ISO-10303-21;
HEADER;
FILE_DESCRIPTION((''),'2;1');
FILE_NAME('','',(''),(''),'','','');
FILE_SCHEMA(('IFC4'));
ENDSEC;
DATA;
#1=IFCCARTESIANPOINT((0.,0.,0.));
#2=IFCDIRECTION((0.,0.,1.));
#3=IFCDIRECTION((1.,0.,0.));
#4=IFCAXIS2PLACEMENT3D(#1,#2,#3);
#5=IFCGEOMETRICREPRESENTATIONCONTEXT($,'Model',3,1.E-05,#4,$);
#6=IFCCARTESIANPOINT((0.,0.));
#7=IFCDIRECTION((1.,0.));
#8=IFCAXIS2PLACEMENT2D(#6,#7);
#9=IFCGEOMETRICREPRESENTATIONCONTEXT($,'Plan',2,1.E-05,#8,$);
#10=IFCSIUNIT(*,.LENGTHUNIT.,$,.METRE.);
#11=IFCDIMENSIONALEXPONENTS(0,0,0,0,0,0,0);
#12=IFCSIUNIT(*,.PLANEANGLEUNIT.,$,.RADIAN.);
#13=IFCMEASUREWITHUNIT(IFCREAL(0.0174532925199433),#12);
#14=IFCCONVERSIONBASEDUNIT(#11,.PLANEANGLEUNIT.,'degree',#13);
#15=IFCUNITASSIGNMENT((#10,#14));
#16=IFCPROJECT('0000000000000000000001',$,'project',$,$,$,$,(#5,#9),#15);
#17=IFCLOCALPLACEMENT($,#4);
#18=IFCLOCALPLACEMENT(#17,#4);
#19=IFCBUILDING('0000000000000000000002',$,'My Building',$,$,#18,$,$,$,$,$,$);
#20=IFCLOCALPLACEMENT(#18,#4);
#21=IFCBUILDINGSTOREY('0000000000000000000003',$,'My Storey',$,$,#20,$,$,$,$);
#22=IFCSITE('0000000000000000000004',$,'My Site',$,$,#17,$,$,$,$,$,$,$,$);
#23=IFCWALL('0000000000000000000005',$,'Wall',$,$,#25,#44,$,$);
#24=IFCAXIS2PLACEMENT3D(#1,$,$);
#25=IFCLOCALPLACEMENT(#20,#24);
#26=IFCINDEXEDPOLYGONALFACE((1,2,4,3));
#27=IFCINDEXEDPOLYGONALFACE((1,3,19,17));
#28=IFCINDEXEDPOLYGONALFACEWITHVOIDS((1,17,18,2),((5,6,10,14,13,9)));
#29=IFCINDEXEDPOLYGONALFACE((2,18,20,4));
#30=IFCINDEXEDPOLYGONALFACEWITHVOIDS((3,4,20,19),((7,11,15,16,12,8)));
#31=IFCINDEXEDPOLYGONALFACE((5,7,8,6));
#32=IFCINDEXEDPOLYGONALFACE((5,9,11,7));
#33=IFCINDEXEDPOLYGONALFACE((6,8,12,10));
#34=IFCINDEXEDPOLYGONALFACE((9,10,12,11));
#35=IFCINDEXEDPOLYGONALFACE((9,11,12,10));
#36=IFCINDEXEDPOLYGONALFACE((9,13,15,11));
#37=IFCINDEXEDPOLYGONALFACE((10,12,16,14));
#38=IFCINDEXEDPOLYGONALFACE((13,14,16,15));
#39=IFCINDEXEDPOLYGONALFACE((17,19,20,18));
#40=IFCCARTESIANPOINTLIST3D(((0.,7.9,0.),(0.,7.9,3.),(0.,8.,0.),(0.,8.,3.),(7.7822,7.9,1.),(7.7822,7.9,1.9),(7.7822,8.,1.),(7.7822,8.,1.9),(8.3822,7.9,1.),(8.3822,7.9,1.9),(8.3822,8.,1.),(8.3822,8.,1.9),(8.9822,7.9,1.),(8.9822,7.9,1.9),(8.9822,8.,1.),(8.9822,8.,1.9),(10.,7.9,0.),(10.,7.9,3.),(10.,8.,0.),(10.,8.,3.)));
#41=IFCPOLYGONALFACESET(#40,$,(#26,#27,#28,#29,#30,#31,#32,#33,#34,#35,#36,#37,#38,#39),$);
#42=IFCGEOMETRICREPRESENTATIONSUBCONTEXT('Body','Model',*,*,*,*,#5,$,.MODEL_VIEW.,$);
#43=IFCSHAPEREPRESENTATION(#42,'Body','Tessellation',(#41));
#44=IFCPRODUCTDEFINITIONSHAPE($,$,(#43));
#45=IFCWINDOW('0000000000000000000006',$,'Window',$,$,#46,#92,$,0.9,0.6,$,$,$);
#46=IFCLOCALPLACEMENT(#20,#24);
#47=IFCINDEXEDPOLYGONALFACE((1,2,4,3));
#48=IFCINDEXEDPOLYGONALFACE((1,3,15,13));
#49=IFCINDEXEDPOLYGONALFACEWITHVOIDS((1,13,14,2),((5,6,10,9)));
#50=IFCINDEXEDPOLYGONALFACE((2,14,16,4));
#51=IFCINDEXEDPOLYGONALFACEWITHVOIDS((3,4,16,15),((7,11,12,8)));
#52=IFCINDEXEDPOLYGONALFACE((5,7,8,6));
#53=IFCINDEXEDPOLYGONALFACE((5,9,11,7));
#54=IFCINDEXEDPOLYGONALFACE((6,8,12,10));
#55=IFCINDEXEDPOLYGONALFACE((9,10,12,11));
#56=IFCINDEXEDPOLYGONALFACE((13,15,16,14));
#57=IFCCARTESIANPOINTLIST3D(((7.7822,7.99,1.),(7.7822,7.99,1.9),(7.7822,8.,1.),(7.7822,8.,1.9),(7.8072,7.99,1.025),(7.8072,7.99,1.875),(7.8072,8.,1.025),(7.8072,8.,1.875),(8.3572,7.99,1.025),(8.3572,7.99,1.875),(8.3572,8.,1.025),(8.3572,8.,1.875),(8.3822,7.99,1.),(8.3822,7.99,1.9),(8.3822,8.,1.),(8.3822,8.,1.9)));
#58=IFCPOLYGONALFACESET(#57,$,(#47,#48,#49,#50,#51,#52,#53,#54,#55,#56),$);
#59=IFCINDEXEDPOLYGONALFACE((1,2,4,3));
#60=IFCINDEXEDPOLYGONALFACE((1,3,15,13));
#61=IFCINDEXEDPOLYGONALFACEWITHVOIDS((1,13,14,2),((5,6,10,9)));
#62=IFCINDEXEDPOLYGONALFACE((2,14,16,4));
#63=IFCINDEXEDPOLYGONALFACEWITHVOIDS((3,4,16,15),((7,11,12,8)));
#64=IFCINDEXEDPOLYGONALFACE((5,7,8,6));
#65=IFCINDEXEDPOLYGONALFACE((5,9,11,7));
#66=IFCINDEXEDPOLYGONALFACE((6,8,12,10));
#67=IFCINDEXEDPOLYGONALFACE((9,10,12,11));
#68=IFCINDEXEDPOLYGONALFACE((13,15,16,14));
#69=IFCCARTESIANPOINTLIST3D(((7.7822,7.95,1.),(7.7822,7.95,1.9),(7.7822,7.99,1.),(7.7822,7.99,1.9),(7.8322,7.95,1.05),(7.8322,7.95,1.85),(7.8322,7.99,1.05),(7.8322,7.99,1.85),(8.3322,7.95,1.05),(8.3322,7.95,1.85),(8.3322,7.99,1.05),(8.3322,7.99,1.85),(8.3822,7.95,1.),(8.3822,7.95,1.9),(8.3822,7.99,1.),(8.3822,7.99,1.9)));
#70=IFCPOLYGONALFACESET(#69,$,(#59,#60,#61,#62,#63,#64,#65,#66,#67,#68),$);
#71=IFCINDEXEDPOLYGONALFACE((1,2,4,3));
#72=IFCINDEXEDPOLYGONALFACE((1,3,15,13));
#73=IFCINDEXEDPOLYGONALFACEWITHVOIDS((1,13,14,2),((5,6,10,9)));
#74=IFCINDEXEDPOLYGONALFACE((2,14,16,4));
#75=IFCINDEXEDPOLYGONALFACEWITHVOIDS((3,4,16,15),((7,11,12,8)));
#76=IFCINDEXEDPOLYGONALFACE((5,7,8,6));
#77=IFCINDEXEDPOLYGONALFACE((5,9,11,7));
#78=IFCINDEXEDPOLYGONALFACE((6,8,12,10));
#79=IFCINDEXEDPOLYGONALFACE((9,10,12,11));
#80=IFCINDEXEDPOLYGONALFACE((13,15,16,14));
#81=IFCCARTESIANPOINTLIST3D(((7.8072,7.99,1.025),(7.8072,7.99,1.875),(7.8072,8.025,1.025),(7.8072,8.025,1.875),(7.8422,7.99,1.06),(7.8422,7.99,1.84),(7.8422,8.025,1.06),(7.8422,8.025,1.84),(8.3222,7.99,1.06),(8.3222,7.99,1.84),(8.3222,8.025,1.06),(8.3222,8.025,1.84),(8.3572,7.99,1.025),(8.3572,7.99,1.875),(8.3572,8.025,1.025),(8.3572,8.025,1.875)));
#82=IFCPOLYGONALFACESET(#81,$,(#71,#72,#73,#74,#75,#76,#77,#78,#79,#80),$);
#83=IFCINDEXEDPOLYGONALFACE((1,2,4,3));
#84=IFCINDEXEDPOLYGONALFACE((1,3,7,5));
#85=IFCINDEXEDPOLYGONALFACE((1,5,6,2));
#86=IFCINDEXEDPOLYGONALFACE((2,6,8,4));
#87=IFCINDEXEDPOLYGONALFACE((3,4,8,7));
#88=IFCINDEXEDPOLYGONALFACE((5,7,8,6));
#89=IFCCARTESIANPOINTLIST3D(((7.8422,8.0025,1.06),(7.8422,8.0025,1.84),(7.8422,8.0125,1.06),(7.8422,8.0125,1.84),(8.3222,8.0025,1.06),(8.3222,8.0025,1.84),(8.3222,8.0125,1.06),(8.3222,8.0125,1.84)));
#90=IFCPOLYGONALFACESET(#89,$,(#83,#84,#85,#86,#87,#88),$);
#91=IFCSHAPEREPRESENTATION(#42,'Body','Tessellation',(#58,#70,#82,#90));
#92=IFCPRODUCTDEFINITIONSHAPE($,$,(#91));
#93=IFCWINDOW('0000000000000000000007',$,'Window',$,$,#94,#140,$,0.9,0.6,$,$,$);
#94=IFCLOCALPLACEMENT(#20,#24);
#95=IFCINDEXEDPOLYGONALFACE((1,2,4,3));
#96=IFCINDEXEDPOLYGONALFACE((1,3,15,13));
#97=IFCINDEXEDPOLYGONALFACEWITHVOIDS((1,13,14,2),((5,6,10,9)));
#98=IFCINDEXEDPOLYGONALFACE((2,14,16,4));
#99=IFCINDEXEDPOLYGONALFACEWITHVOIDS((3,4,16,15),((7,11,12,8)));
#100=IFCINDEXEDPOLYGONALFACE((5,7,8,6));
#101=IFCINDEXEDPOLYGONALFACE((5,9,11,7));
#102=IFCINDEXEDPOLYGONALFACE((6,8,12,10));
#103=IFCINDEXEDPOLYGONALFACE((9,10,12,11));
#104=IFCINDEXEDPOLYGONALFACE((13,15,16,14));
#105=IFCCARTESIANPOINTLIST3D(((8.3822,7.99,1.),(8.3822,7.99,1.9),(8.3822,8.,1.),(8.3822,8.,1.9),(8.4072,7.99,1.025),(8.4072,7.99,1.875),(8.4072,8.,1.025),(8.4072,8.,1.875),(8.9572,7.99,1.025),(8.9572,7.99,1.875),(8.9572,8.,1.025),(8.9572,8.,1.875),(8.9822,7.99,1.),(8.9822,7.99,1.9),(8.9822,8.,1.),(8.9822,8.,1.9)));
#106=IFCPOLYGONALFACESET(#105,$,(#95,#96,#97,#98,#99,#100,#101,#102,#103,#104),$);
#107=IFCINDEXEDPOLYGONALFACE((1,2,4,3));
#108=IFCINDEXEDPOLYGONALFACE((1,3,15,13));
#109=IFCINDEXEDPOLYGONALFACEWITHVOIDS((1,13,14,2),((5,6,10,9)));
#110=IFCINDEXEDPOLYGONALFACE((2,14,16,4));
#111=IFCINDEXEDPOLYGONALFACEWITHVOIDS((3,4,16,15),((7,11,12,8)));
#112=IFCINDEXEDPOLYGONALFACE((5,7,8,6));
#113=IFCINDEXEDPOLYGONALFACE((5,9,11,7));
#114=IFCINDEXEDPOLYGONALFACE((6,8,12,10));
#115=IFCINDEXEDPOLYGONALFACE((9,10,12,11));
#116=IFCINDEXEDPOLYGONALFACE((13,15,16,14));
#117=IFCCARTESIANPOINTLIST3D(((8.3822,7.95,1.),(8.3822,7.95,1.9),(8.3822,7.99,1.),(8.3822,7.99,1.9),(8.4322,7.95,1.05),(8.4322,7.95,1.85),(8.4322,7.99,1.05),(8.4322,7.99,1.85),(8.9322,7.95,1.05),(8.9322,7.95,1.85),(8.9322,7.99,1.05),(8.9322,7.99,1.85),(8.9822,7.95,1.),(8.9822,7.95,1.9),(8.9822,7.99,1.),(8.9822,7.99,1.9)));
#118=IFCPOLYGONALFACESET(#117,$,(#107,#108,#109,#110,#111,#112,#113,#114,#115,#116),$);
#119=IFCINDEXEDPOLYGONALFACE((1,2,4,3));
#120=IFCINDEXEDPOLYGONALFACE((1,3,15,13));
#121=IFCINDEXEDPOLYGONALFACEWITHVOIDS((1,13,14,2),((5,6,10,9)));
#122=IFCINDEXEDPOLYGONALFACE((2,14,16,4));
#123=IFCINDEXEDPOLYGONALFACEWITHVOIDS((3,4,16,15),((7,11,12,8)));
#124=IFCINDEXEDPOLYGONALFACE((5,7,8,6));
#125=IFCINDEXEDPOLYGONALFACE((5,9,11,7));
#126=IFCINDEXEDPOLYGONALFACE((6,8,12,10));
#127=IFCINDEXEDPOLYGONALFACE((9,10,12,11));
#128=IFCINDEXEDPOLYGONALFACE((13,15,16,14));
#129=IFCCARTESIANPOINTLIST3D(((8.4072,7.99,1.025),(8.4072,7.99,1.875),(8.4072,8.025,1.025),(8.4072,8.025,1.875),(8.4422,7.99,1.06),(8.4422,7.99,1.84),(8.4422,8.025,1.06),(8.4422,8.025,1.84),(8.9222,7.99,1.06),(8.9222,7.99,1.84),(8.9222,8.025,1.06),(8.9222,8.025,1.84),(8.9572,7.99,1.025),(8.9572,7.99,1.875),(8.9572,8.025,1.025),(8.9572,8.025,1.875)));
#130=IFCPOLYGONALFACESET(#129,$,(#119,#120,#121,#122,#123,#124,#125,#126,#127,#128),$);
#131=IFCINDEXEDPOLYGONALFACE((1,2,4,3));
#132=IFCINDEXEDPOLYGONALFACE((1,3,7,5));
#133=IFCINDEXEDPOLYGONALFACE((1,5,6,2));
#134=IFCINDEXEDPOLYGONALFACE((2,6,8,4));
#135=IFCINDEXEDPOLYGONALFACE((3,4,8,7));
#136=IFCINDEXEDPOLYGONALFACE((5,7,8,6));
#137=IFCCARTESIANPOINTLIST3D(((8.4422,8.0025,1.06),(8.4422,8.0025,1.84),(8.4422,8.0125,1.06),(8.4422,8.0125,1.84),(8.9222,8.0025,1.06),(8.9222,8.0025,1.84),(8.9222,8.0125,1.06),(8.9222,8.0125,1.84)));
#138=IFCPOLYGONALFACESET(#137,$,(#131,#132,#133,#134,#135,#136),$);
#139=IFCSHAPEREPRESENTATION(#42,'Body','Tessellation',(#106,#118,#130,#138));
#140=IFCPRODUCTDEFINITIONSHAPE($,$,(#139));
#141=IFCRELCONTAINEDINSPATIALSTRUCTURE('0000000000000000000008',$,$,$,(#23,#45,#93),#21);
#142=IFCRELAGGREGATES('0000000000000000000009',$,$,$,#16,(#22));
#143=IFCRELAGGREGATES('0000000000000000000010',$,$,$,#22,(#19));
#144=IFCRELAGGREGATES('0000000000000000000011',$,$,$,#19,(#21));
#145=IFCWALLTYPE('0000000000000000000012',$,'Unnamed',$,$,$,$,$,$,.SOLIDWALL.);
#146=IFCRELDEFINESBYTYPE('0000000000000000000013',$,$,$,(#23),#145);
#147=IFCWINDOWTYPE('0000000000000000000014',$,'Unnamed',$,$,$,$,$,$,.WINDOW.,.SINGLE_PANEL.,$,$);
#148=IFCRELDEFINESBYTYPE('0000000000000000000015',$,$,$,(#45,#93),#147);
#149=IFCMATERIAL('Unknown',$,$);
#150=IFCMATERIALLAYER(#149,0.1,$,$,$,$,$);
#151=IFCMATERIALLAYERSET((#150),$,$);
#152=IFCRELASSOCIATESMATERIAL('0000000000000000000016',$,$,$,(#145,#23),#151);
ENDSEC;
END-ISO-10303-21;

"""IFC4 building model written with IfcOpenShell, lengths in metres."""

from ifc_helpers import new_model, entity, si_unit, converted_unit, frame, origin_with_axes, origin_2d_with_axis, place, context, subcontext, project, spatial, line, indexed_curve, outline, extrude, shape, source, transform, mapped, material, layer, layer_set, layer_usage, type_object, type_shapes, element, fill, save


model = new_model("IFC4")

# Units and contexts
model_context = context("Model", 3, precision=1e-05, world=origin_with_axes())
plan_context = context("Plan", 2, precision=1e-05, world=origin_2d_with_axis())
body_context_1 = subcontext(model_context, "Body", "Model", "MODEL_VIEW")
body_context_2 = subcontext(plan_context, "Body", "Plan", "PLAN_VIEW")
ifc_project = project(units=[si_unit("LENGTHUNIT", "METRE"), converted_unit("PLANEANGLEUNIT", "degree", entity("IfcReal", 0.0174532925199433), si_unit("PLANEANGLEUNIT", "RADIAN"), dimensions=[0, 0, 0, 0, 0, 0, 0])], contexts=[model_context, plan_context])

# Site, building, storey
site_placement = place(None, origin_with_axes())
site = spatial("IfcSite", under=ifc_project, at=site_placement, Name="My Site")
building_placement = place(site_placement, origin_with_axes())
building = spatial("IfcBuilding", under=site, at=building_placement, Name="My Building")
storey_placement = place(building_placement, origin_with_axes())
storey = spatial("IfcBuildingStorey", under=building, at=storey_placement, Name="My Storey")

# Shared definitions
ifc_material = material(Name="Unknown")

# Shared definitions
ifc_layer_1 = layer(ifc_material, 0.1)
ifc_layer_set_1 = layer_set([ifc_layer_1])
wall_type = type_object("IfcWallType", Name="Unnamed", PredefinedType="SOLIDWALL", material=ifc_layer_set_1)
shared_shape_1 = source(origin_with_axes(), body_context_1, "Body", "SweptSolid", [
    extrude(outline(indexed_curve([(0.0, 0.0), (0.6, 0.0), (0.6, 0.9), (0.0, 0.9)], segments=[line(1, 2, 3, 4, 1)])), frame((0.0, -0.6, 0.0), z_axis=(0.0, -1.0, 0.0), x_axis=(1.0, 0.0, 0.0)), (0.0, 0.0, -1.0), 1.2),
])
window_type = type_object("IfcWindowType", Name="Unnamed", PartitioningType="SINGLE_PANEL", PredefinedType="WINDOW")
shared_shape_2 = source(origin_with_axes(), body_context_1, "Body", "SweptSolid", [
    extrude(outline(indexed_curve([(0.0, 0.0), (0.6, 0.0), (0.6, 0.9), (0.0, 0.9)], segments=[line(1, 2, 3, 4, 1)]), holes=[indexed_curve([(0.025, 0.025), (0.575, 0.025), (0.575, 0.875), (0.025, 0.875)], segments=[line(1, 2, 3, 4, 1)])]), frame((0.0, 0.09, 0.0), z_axis=(0.0, -1.0, 0.0), x_axis=(1.0, 0.0, 0.0)), (0.0, 0.0, -1.0), 0.01),
    extrude(outline(indexed_curve([(0.0, 0.0), (0.6, 0.0), (0.6, 0.9), (0.0, 0.9)], segments=[line(1, 2, 3, 4, 1)]), holes=[indexed_curve([(0.05, 0.05), (0.55, 0.05), (0.55, 0.85), (0.05, 0.85)], segments=[line(1, 2, 3, 4, 1)])]), frame((0.0, 0.05, 0.0), z_axis=(0.0, -1.0, 0.0), x_axis=(1.0, 0.0, 0.0)), (0.0, 0.0, -1.0), 0.04),
    extrude(outline(indexed_curve([(0.0, 0.0), (0.55, 0.0), (0.55, 0.85), (0.0, 0.85)], segments=[line(1, 2, 3, 4, 1)]), holes=[indexed_curve([(0.035, 0.035), (0.515, 0.035), (0.515, 0.815), (0.035, 0.815)], segments=[line(1, 2, 3, 4, 1)])]), frame((0.025, 0.09, 0.025), z_axis=(0.0, -1.0, 0.0), x_axis=(1.0, 0.0, 0.0)), (0.0, 0.0, -1.0), 0.035),
    extrude(outline(indexed_curve([(0.035, 0.035), (0.515, 0.035), (0.515, 0.815), (0.035, 0.815)], segments=[line(1, 2, 3, 4, 1)])), frame((0.025, 0.1025, 0.025), z_axis=(0.0, -1.0, 0.0), x_axis=(1.0, 0.0, 0.0)), (0.0, 0.0, -1.0), 0.01),
])
shared_shape_3 = source(origin_with_axes(), body_context_2, "Body", "Curve2D", [
    entity("IfcIndexedPolyCurve", entity("IfcCartesianPointList2D", [[0.05, 0.05], [0.55, 0.05]])),
    entity("IfcIndexedPolyCurve", entity("IfcCartesianPointList2D", [[0.0, 0.1], [0.025, 0.1], [0.025, 0.09], [0.05, 0.09], [0.05, 0.05], [0.0, 0.05]]), [entity("IfcLineIndex", [1, 2, 3, 4, 5, 6, 1])]),
    entity("IfcIndexedPolyCurve", entity("IfcCartesianPointList2D", [[0.6, 0.1], [0.575, 0.1], [0.575, 0.09], [0.55, 0.09], [0.55, 0.05], [0.6, 0.05]]), [entity("IfcLineIndex", [1, 2, 3, 4, 5, 6, 1])]),
    entity("IfcIndexedPolyCurve", entity("IfcCartesianPointList2D", [[0.025, 0.09], [0.06, 0.09], [0.06, 0.125], [0.025, 0.125]]), [entity("IfcLineIndex", [1, 2, 3, 4, 1])]),
    entity("IfcIndexedPolyCurve", entity("IfcCartesianPointList2D", [[0.575, 0.09], [0.54, 0.09], [0.54, 0.125], [0.575, 0.125]]), [entity("IfcLineIndex", [1, 2, 3, 4, 1])]),
    entity("IfcIndexedPolyCurve", entity("IfcCartesianPointList2D", [[0.06, 0.09], [0.54, 0.09]])),
    entity("IfcIndexedPolyCurve", entity("IfcCartesianPointList2D", [[0.06, 0.125], [0.54, 0.125]])),
    entity("IfcIndexedPolyCurve", entity("IfcCartesianPointList2D", [[0.06, 0.1075], [0.54, 0.1075]])),
])
type_shapes(window_type, [shared_shape_2, shared_shape_3])

# Wall, openings, windows
ifc_layer_usage_1 = layer_usage(ifc_layer_set_1, "AXIS2", "POSITIVE", 0.0)
wall_1_placement = place(storey_placement, frame((0.0, 7.9, 0.0), z_axis=(0.0, 0.0, 1.0), x_axis=(1.0, 0.0, 0.0)))
wall_1 = element("IfcWall", 1, at=wall_1_placement, inside=storey, type_object=wall_type, material=ifc_layer_usage_1, Name="Wall", context=body_context_1, shape_type="SweptSolid", body=[
    extrude(outline(indexed_curve([(0.0, 0.0), (0.0, 0.1), (10.0, 0.1), (10.0, 0.0)], segments=[line(1, 2, 3, 4, 1)])), origin_with_axes(), (0.0, 0.0, 1.0), 3.0),
])
opening_1_placement = place(wall_1_placement, frame((7.7822, 0.0, 1.0), z_axis=(0.0, 0.0, 1.0), x_axis=(1.0, 0.0, 0.0)))
opening_1 = element("IfcOpeningElement", 2, at=opening_1_placement, cuts=wall_1, PredefinedType="OPENING", context=body_context_1, shape_type="MappedRepresentation", body=[
    mapped(shared_shape_1, transform((0.0, 0.0, 0.0), x_axis=(1.0, 0.0, 0.0), y_axis=(0.0, 1.0, 0.0), z_axis=(0.0, 0.0, 1.0), scale=1.0)),
])
opening_2_placement = place(wall_1_placement, frame((8.3822, 0.0, 1.0), z_axis=(0.0, 0.0, 1.0), x_axis=(1.0, 0.0, 0.0)))
opening_2 = element("IfcOpeningElement", 3, at=opening_2_placement, cuts=wall_1, PredefinedType="OPENING", context=body_context_1, shape_type="MappedRepresentation", body=[
    mapped(shared_shape_1, transform((0.0, 0.0, 0.0), x_axis=(1.0, 0.0, 0.0), y_axis=(0.0, 1.0, 0.0), z_axis=(0.0, 0.0, 1.0), scale=1.0)),
])
window_1_placement = place(opening_1_placement, origin_with_axes())
window_1 = element("IfcWindow", 4, at=window_1_placement, inside=storey, type_object=window_type, Name="Window", OverallHeight=0.9, OverallWidth=0.6, shapes=[
    shape(body_context_1, "Body", "MappedRepresentation", [mapped(shared_shape_2, transform((0.0, 0.0, 0.0), x_axis=(1.0, 0.0, 0.0), y_axis=(0.0, 1.0, 0.0), z_axis=(0.0, 0.0, 1.0), scale=1.0))]),
    shape(body_context_2, "Body", "MappedRepresentation", [mapped(shared_shape_3, transform((0.0, 0.0, 0.0), x_axis=(1.0, 0.0, 0.0), y_axis=(0.0, 1.0, 0.0), z_axis=(0.0, 0.0, 1.0), scale=1.0))]),
])
fill(opening_1, window_1)
window_2_placement = place(opening_2_placement, origin_with_axes())
window_2 = element("IfcWindow", 5, at=window_2_placement, inside=storey, type_object=window_type, Name="Window", OverallHeight=0.9, OverallWidth=0.6, shapes=[
    shape(body_context_1, "Body", "MappedRepresentation", [mapped(shared_shape_2, transform((0.0, 0.0, 0.0), x_axis=(1.0, 0.0, 0.0), y_axis=(0.0, 1.0, 0.0), z_axis=(0.0, 0.0, 1.0), scale=1.0))]),
    shape(body_context_2, "Body", "MappedRepresentation", [mapped(shared_shape_3, transform((0.0, 0.0, 0.0), x_axis=(1.0, 0.0, 0.0), y_axis=(0.0, 1.0, 0.0), z_axis=(0.0, 0.0, 1.0), scale=1.0))]),
])
fill(opening_2, window_2)

save(model, "model.ifc")
